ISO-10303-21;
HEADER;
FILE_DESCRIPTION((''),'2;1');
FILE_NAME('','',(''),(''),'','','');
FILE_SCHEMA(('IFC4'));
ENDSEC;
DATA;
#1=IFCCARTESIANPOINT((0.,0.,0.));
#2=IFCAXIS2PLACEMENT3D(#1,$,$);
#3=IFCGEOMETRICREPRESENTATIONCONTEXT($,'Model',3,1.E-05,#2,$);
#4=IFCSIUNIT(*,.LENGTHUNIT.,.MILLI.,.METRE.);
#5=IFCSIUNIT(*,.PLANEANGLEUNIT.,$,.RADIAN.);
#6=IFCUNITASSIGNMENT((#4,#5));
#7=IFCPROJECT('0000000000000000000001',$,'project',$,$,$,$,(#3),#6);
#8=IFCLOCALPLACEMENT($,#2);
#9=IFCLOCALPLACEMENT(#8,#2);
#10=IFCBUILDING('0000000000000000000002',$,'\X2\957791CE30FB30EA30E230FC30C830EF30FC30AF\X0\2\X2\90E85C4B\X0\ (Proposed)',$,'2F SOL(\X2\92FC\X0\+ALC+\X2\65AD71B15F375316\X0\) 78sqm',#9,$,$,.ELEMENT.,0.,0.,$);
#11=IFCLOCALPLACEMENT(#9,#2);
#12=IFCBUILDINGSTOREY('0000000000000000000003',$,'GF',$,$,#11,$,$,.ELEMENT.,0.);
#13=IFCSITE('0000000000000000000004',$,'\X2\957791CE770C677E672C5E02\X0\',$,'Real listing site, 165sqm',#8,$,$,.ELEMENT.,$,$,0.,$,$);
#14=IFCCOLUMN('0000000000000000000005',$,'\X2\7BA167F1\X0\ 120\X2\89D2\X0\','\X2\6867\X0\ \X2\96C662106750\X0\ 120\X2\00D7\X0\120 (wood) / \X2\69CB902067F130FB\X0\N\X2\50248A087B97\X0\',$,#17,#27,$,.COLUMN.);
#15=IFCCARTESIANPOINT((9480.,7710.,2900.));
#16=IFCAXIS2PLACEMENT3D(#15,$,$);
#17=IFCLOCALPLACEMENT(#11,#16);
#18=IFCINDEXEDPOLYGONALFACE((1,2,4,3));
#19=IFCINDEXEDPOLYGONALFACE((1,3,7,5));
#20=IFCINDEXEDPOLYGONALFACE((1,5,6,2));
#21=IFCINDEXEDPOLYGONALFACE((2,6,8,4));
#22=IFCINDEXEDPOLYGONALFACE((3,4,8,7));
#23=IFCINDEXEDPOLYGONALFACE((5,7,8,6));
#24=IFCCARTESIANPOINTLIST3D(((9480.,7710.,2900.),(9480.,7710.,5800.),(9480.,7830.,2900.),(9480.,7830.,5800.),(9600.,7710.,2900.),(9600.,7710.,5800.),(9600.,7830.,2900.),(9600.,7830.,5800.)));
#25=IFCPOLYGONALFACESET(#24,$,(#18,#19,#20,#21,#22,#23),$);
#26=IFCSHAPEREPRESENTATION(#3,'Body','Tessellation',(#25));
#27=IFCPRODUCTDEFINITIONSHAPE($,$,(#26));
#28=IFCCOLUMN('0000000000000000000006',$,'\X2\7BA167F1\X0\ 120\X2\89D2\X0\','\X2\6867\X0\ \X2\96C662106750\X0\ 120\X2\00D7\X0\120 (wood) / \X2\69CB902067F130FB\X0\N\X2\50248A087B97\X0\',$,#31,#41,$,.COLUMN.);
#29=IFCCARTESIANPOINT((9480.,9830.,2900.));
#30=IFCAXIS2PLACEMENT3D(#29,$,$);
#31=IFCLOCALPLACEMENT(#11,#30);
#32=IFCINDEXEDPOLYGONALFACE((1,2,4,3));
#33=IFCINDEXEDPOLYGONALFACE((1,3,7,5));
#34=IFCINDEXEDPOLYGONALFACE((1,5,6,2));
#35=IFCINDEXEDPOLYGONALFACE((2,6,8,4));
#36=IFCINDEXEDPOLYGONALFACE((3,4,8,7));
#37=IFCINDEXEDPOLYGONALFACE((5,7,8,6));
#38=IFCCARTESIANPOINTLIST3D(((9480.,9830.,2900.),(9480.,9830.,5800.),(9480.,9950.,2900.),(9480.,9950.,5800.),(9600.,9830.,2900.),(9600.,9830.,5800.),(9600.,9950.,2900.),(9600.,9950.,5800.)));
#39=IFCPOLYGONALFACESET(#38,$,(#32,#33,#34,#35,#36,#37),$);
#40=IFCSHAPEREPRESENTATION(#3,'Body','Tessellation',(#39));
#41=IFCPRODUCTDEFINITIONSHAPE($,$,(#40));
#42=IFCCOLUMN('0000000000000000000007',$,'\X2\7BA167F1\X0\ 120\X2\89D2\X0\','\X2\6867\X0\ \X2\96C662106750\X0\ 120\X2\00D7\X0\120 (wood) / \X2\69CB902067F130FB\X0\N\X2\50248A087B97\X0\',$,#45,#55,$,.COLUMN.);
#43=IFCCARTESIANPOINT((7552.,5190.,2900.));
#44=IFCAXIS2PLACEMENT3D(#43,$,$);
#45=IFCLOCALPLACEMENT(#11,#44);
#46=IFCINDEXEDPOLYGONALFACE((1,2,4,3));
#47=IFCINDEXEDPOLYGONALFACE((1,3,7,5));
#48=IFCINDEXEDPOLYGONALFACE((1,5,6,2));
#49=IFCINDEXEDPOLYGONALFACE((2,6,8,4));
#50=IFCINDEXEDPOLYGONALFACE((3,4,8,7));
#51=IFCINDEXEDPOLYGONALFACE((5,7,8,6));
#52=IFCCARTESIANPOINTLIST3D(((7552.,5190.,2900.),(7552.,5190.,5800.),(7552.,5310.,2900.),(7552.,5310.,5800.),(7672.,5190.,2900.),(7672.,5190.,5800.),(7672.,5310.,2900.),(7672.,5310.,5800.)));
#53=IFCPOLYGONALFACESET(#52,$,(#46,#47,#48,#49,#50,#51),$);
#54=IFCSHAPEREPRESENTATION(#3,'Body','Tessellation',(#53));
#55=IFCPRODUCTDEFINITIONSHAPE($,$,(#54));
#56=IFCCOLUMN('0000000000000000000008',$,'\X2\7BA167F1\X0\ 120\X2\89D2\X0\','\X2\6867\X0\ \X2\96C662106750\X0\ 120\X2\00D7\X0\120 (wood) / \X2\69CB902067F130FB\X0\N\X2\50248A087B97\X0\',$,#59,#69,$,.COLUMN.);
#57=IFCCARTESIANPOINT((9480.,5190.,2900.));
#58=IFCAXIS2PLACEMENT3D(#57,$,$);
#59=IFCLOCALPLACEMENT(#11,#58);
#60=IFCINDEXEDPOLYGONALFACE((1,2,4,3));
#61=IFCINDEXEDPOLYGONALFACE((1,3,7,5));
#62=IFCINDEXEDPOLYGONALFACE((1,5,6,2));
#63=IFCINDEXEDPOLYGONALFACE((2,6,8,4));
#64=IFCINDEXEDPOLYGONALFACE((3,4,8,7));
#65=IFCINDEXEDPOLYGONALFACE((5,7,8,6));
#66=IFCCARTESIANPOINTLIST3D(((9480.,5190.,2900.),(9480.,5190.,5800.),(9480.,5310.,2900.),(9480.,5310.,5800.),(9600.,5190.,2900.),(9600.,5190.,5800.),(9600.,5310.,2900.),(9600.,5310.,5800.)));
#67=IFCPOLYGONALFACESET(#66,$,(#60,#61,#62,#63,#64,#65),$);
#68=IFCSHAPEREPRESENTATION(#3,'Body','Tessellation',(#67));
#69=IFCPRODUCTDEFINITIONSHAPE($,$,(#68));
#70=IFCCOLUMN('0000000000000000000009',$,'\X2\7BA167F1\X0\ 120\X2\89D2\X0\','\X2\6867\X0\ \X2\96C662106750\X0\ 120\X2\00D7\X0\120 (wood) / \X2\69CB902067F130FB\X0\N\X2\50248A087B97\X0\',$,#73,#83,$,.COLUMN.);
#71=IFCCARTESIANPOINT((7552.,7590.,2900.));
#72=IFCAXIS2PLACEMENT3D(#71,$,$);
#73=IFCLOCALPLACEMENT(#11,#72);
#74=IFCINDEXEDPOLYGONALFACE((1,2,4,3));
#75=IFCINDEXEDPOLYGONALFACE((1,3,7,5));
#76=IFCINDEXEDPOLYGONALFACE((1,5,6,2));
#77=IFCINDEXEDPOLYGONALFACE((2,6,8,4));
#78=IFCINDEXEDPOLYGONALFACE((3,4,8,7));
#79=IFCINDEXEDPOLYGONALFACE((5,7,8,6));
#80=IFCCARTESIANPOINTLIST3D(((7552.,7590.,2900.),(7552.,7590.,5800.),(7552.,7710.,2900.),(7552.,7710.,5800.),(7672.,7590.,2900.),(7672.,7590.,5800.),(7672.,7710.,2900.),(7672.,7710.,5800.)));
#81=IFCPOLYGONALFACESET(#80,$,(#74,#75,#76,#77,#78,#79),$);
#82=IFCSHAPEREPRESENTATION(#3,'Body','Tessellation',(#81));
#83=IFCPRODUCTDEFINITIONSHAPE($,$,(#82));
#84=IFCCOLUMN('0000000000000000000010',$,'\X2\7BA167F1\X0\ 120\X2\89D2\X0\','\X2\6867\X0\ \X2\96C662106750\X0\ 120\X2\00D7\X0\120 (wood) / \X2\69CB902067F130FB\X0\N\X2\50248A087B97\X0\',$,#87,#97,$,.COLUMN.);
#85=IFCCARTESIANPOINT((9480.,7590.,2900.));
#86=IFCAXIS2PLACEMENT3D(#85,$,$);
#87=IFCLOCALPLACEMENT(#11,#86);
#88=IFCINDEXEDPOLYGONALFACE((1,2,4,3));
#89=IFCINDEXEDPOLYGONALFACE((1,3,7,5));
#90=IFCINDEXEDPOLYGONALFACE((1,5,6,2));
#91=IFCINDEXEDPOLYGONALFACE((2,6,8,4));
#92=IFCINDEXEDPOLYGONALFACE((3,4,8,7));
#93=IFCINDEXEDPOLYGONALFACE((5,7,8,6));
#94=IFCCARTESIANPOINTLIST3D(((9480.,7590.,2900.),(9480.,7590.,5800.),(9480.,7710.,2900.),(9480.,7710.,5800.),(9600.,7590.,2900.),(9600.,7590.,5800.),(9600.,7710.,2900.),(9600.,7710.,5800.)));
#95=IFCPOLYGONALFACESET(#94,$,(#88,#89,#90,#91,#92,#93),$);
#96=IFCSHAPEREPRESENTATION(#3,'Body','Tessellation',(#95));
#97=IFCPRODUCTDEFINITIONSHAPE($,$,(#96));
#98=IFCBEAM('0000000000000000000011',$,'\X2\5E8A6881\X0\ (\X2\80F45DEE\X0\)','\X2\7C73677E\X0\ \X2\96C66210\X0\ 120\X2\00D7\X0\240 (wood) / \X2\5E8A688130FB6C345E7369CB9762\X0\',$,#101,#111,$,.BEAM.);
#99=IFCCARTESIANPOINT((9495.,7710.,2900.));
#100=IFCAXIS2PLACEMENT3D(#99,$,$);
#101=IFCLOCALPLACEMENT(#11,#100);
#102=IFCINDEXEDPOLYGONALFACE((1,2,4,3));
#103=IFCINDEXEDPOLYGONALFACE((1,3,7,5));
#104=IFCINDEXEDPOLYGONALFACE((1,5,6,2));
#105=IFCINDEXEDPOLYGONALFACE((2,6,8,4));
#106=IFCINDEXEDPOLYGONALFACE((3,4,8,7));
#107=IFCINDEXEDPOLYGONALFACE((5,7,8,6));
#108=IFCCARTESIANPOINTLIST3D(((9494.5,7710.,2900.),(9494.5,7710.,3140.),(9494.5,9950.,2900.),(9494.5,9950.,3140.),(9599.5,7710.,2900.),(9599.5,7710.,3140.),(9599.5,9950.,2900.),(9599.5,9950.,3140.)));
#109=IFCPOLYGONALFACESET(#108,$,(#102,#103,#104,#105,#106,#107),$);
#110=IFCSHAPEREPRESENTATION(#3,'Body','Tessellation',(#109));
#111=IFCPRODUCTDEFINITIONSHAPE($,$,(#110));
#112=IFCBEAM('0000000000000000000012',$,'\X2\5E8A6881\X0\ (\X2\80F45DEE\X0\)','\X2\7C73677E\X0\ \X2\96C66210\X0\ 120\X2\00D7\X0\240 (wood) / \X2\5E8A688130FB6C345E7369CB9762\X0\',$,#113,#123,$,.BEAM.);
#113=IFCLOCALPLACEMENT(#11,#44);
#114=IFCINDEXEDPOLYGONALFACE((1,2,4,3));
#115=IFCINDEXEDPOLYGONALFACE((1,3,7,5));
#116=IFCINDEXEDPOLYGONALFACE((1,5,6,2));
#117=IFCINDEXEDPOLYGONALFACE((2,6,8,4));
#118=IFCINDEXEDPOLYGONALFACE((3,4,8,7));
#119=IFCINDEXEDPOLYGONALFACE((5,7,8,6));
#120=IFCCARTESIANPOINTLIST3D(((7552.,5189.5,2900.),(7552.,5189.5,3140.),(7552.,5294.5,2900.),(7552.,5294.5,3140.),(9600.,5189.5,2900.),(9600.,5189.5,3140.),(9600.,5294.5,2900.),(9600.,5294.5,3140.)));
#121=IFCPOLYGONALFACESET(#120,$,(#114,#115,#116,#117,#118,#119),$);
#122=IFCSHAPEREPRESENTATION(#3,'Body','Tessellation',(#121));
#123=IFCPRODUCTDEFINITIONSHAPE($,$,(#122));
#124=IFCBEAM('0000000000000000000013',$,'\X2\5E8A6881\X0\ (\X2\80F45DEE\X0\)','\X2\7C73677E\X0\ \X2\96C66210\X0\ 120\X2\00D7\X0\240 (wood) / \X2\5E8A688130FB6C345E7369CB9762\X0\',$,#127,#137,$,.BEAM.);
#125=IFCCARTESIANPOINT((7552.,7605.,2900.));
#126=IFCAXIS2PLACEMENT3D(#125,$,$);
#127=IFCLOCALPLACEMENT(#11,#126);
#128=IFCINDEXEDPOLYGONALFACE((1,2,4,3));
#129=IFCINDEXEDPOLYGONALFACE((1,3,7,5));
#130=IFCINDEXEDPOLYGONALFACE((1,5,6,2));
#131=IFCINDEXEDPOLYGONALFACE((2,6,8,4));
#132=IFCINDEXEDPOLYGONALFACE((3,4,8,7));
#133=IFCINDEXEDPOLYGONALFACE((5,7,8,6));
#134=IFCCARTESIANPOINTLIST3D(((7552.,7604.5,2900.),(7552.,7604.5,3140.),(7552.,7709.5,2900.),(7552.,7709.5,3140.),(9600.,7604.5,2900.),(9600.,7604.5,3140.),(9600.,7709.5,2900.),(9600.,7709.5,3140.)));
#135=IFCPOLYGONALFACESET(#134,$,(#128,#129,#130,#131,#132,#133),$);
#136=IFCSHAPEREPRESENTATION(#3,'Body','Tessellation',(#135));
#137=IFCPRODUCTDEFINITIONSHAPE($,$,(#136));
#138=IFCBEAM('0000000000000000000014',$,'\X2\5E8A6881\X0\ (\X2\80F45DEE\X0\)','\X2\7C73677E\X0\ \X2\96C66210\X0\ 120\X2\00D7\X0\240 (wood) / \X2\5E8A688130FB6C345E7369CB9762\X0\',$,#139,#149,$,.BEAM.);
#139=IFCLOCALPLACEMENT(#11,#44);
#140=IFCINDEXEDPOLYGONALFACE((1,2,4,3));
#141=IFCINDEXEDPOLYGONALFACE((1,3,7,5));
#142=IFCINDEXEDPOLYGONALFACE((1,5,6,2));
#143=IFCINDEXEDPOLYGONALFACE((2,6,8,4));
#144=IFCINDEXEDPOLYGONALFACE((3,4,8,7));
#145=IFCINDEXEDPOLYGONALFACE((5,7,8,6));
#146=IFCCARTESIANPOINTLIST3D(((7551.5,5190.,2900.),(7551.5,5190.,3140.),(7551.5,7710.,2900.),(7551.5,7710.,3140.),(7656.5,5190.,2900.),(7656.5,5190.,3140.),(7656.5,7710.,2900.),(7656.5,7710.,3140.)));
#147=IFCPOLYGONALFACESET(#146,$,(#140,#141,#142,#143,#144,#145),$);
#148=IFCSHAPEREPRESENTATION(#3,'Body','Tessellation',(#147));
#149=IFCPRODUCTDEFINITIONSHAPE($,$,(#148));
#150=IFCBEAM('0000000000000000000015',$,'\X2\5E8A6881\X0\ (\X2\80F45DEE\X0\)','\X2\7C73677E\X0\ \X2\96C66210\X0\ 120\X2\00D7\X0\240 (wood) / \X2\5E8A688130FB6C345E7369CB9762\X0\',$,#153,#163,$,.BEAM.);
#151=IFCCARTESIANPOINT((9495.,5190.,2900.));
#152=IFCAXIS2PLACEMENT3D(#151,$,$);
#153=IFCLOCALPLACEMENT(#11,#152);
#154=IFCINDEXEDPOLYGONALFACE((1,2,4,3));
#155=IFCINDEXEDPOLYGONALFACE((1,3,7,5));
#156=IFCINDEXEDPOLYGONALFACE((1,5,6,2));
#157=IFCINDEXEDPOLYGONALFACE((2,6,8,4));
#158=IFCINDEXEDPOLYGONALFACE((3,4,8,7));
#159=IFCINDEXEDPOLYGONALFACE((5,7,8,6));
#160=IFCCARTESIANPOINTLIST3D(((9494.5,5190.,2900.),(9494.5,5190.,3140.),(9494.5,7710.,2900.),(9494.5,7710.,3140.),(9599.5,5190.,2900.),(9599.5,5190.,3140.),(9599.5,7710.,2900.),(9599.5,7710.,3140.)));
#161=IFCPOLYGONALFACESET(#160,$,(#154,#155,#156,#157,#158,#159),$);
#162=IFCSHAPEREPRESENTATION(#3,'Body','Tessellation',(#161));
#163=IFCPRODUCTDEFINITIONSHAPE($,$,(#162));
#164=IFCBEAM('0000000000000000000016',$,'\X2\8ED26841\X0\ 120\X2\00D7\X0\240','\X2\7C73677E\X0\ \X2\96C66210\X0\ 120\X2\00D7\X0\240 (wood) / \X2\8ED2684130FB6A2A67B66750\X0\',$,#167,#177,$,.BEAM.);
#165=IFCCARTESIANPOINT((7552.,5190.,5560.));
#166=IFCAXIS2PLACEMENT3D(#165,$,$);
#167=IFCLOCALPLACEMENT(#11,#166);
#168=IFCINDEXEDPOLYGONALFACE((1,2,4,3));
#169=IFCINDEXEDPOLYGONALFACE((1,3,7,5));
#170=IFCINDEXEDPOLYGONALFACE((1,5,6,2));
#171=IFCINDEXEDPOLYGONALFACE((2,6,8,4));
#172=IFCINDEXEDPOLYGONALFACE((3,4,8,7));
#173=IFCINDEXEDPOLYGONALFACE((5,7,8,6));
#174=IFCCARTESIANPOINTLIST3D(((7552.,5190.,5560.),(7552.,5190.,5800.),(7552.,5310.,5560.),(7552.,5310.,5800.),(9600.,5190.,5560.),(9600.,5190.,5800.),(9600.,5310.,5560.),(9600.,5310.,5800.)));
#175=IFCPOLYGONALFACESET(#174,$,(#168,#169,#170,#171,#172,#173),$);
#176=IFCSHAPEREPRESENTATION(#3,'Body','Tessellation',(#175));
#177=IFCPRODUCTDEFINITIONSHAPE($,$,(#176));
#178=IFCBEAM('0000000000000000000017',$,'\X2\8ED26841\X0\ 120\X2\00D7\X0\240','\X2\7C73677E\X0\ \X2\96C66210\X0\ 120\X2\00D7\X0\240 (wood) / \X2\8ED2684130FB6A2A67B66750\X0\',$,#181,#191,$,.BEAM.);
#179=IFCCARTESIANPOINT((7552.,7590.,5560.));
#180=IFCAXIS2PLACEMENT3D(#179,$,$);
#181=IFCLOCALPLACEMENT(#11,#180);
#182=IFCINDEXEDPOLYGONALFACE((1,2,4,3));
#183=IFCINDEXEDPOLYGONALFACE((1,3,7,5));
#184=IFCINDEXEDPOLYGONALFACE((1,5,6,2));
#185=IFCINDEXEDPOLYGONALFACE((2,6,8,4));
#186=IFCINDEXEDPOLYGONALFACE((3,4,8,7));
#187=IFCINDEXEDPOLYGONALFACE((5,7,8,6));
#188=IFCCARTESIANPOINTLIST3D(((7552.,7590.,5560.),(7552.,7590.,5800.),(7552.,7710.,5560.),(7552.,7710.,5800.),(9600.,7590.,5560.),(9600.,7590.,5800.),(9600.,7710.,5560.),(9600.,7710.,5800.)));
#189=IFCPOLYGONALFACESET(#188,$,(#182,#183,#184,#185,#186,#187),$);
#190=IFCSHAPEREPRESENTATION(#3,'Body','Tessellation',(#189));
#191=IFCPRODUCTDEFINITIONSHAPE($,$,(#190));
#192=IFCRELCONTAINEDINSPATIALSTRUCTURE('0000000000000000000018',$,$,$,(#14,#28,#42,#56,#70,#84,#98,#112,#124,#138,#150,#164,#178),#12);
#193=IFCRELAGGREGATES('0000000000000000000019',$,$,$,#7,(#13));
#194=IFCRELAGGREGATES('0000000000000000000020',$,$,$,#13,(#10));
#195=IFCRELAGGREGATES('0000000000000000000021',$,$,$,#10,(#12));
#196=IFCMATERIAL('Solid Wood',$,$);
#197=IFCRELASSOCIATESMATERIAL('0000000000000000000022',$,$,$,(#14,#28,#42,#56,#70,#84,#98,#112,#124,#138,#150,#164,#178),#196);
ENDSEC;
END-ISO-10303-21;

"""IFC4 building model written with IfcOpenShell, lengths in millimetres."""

from ifc_helpers import new_model, si_unit, frame, frame_2d, origin, place, context, project, spatial, rectangle, extrude, material, element, save


model = new_model("IFC4")

# Units and contexts
model_context = context("Model", 3, precision=1e-05, world=origin())
ifc_project = project(units=[si_unit("LENGTHUNIT", "METRE", prefix="MILLI"), si_unit("PLANEANGLEUNIT", "RADIAN")], contexts=[model_context])

# Site, building, storey
site_placement = place(None, origin())
site = spatial("IfcSite", under=ifc_project, at=site_placement, Name="長野県松本市", ObjectType="Real listing site, 165sqm", CompositionType="ELEMENT", RefElevation=0.0)
building_placement = place(site_placement, origin())
building = spatial("IfcBuilding", under=site, at=building_placement, Name="長野・リモートワーク2部屋 (Proposed)", ObjectType="2F SOL(鋼+ALC+断熱強化) 78sqm", CompositionType="ELEMENT", ElevationOfRefHeight=0.0, ElevationOfTerrain=0.0)
storey_placement = place(building_placement, origin())
storey = spatial("IfcBuildingStorey", under=building, at=storey_placement, Name="GF", CompositionType="ELEMENT", Elevation=0.0)

# Columns
ifc_material_1 = material(Name="Solid Wood")
column_1_placement = place(storey_placement, frame((9480.0, 7710.0, 2900.0)))
element("IfcColumn", 1, at=column_1_placement, inside=storey, material=ifc_material_1, Name="管柱 120角", Description="桧 集成材 120×120 (wood) / 構造柱・N値計算", PredefinedType="COLUMN", context=model_context, shape_type="SweptSolid", body=[
    extrude(rectangle(XDim=120.0, YDim=120.0, at=frame_2d((60.0, 60.0))), frame((9480.0, 7710.0, 2900.0)), (0.0, 0.0, 1.0), 2900.0),
])
column_2_placement = place(storey_placement, frame((9480.0, 9830.0, 2900.0)))
element("IfcColumn", 2, at=column_2_placement, inside=storey, material=ifc_material_1, Name="管柱 120角", Description="桧 集成材 120×120 (wood) / 構造柱・N値計算", PredefinedType="COLUMN", context=model_context, shape_type="SweptSolid", body=[
    extrude(rectangle(XDim=120.0, YDim=120.0, at=frame_2d((60.0, 60.0))), frame((9480.0, 9830.0, 2900.0)), (0.0, 0.0, 1.0), 2900.0),
])
column_3_placement = place(storey_placement, frame((7552.0, 5190.0, 2900.0)))
element("IfcColumn", 3, at=column_3_placement, inside=storey, material=ifc_material_1, Name="管柱 120角", Description="桧 集成材 120×120 (wood) / 構造柱・N値計算", PredefinedType="COLUMN", context=model_context, shape_type="SweptSolid", body=[
    extrude(rectangle(XDim=120.0, YDim=120.0, at=frame_2d((60.0, 60.0))), frame((7552.0, 5190.0, 2900.0)), (0.0, 0.0, 1.0), 2900.0),
])
column_4_placement = place(storey_placement, frame((9480.0, 5190.0, 2900.0)))
element("IfcColumn", 4, at=column_4_placement, inside=storey, material=ifc_material_1, Name="管柱 120角", Description="桧 集成材 120×120 (wood) / 構造柱・N値計算", PredefinedType="COLUMN", context=model_context, shape_type="SweptSolid", body=[
    extrude(rectangle(XDim=120.0, YDim=120.0, at=frame_2d((60.0, 60.0))), frame((9480.0, 5190.0, 2900.0)), (0.0, 0.0, 1.0), 2900.0),
])
column_5_placement = place(storey_placement, frame((7552.0, 7590.0, 2900.0)))
element("IfcColumn", 5, at=column_5_placement, inside=storey, material=ifc_material_1, Name="管柱 120角", Description="桧 集成材 120×120 (wood) / 構造柱・N値計算", PredefinedType="COLUMN", context=model_context, shape_type="SweptSolid", body=[
    extrude(rectangle(XDim=120.0, YDim=120.0, at=frame_2d((60.0, 60.0))), frame((7552.0, 7590.0, 2900.0)), (0.0, 0.0, 1.0), 2900.0),
])
column_6_placement = place(storey_placement, frame((9480.0, 7590.0, 2900.0)))
element("IfcColumn", 6, at=column_6_placement, inside=storey, material=ifc_material_1, Name="管柱 120角", Description="桧 集成材 120×120 (wood) / 構造柱・N値計算", PredefinedType="COLUMN", context=model_context, shape_type="SweptSolid", body=[
    extrude(rectangle(XDim=120.0, YDim=120.0, at=frame_2d((60.0, 60.0))), frame((9480.0, 7590.0, 2900.0)), (0.0, 0.0, 1.0), 2900.0),
])

# Beams
beam_1_placement = place(storey_placement, frame((9495.0, 7710.0, 2900.0)))
element("IfcBeam", 7, at=beam_1_placement, inside=storey, material=ifc_material_1, Name="床梁 (胴差)", Description="米松 集成 120×240 (wood) / 床梁・水平構面", PredefinedType="BEAM", context=model_context, shape_type="SweptSolid", body=[
    extrude(rectangle(XDim=105.0, YDim=2240.0, at=frame_2d((52.0, 1120.0))), frame((9495.0, 7710.0, 2900.0)), (0.0, 0.0, 1.0), 240.0),
])
beam_2_placement = place(storey_placement, frame((7552.0, 5190.0, 2900.0)))
element("IfcBeam", 8, at=beam_2_placement, inside=storey, material=ifc_material_1, Name="床梁 (胴差)", Description="米松 集成 120×240 (wood) / 床梁・水平構面", PredefinedType="BEAM", context=model_context, shape_type="SweptSolid", body=[
    extrude(rectangle(XDim=2048.0, YDim=105.0, at=frame_2d((1024.0, 52.0))), frame((7552.0, 5190.0, 2900.0)), (0.0, 0.0, 1.0), 240.0),
])
beam_3_placement = place(storey_placement, frame((7552.0, 7605.0, 2900.0)))
element("IfcBeam", 9, at=beam_3_placement, inside=storey, material=ifc_material_1, Name="床梁 (胴差)", Description="米松 集成 120×240 (wood) / 床梁・水平構面", PredefinedType="BEAM", context=model_context, shape_type="SweptSolid", body=[
    extrude(rectangle(XDim=2048.0, YDim=105.0, at=frame_2d((1024.0, 52.0))), frame((7552.0, 7605.0, 2900.0)), (0.0, 0.0, 1.0), 240.0),
])
beam_4_placement = place(storey_placement, frame((7552.0, 5190.0, 2900.0)))
element("IfcBeam", 10, at=beam_4_placement, inside=storey, material=ifc_material_1, Name="床梁 (胴差)", Description="米松 集成 120×240 (wood) / 床梁・水平構面", PredefinedType="BEAM", context=model_context, shape_type="SweptSolid", body=[
    extrude(rectangle(XDim=105.0, YDim=2520.0, at=frame_2d((52.0, 1260.0))), frame((7552.0, 5190.0, 2900.0)), (0.0, 0.0, 1.0), 240.0),
])
beam_5_placement = place(storey_placement, frame((9495.0, 5190.0, 2900.0)))
element("IfcBeam", 11, at=beam_5_placement, inside=storey, material=ifc_material_1, Name="床梁 (胴差)", Description="米松 集成 120×240 (wood) / 床梁・水平構面", PredefinedType="BEAM", context=model_context, shape_type="SweptSolid", body=[
    extrude(rectangle(XDim=105.0, YDim=2520.0, at=frame_2d((52.0, 1260.0))), frame((9495.0, 5190.0, 2900.0)), (0.0, 0.0, 1.0), 240.0),
])
beam_6_placement = place(storey_placement, frame((7552.0, 5190.0, 5560.0)))
element("IfcBeam", 12, at=beam_6_placement, inside=storey, material=ifc_material_1, Name="軒桁 120×240", Description="米松 集成 120×240 (wood) / 軒桁・横架材", PredefinedType="BEAM", context=model_context, shape_type="SweptSolid", body=[
    extrude(rectangle(XDim=2048.0, YDim=120.0, at=frame_2d((1024.0, 60.0))), frame((7552.0, 5190.0, 5560.0)), (0.0, 0.0, 1.0), 240.0),
])
beam_7_placement = place(storey_placement, frame((7552.0, 7590.0, 5560.0)))
element("IfcBeam", 13, at=beam_7_placement, inside=storey, material=ifc_material_1, Name="軒桁 120×240", Description="米松 集成 120×240 (wood) / 軒桁・横架材", PredefinedType="BEAM", context=model_context, shape_type="SweptSolid", body=[
    extrude(rectangle(XDim=2048.0, YDim=120.0, at=frame_2d((1024.0, 60.0))), frame((7552.0, 7590.0, 5560.0)), (0.0, 0.0, 1.0), 240.0),
])

save(model, "model.ifc")
